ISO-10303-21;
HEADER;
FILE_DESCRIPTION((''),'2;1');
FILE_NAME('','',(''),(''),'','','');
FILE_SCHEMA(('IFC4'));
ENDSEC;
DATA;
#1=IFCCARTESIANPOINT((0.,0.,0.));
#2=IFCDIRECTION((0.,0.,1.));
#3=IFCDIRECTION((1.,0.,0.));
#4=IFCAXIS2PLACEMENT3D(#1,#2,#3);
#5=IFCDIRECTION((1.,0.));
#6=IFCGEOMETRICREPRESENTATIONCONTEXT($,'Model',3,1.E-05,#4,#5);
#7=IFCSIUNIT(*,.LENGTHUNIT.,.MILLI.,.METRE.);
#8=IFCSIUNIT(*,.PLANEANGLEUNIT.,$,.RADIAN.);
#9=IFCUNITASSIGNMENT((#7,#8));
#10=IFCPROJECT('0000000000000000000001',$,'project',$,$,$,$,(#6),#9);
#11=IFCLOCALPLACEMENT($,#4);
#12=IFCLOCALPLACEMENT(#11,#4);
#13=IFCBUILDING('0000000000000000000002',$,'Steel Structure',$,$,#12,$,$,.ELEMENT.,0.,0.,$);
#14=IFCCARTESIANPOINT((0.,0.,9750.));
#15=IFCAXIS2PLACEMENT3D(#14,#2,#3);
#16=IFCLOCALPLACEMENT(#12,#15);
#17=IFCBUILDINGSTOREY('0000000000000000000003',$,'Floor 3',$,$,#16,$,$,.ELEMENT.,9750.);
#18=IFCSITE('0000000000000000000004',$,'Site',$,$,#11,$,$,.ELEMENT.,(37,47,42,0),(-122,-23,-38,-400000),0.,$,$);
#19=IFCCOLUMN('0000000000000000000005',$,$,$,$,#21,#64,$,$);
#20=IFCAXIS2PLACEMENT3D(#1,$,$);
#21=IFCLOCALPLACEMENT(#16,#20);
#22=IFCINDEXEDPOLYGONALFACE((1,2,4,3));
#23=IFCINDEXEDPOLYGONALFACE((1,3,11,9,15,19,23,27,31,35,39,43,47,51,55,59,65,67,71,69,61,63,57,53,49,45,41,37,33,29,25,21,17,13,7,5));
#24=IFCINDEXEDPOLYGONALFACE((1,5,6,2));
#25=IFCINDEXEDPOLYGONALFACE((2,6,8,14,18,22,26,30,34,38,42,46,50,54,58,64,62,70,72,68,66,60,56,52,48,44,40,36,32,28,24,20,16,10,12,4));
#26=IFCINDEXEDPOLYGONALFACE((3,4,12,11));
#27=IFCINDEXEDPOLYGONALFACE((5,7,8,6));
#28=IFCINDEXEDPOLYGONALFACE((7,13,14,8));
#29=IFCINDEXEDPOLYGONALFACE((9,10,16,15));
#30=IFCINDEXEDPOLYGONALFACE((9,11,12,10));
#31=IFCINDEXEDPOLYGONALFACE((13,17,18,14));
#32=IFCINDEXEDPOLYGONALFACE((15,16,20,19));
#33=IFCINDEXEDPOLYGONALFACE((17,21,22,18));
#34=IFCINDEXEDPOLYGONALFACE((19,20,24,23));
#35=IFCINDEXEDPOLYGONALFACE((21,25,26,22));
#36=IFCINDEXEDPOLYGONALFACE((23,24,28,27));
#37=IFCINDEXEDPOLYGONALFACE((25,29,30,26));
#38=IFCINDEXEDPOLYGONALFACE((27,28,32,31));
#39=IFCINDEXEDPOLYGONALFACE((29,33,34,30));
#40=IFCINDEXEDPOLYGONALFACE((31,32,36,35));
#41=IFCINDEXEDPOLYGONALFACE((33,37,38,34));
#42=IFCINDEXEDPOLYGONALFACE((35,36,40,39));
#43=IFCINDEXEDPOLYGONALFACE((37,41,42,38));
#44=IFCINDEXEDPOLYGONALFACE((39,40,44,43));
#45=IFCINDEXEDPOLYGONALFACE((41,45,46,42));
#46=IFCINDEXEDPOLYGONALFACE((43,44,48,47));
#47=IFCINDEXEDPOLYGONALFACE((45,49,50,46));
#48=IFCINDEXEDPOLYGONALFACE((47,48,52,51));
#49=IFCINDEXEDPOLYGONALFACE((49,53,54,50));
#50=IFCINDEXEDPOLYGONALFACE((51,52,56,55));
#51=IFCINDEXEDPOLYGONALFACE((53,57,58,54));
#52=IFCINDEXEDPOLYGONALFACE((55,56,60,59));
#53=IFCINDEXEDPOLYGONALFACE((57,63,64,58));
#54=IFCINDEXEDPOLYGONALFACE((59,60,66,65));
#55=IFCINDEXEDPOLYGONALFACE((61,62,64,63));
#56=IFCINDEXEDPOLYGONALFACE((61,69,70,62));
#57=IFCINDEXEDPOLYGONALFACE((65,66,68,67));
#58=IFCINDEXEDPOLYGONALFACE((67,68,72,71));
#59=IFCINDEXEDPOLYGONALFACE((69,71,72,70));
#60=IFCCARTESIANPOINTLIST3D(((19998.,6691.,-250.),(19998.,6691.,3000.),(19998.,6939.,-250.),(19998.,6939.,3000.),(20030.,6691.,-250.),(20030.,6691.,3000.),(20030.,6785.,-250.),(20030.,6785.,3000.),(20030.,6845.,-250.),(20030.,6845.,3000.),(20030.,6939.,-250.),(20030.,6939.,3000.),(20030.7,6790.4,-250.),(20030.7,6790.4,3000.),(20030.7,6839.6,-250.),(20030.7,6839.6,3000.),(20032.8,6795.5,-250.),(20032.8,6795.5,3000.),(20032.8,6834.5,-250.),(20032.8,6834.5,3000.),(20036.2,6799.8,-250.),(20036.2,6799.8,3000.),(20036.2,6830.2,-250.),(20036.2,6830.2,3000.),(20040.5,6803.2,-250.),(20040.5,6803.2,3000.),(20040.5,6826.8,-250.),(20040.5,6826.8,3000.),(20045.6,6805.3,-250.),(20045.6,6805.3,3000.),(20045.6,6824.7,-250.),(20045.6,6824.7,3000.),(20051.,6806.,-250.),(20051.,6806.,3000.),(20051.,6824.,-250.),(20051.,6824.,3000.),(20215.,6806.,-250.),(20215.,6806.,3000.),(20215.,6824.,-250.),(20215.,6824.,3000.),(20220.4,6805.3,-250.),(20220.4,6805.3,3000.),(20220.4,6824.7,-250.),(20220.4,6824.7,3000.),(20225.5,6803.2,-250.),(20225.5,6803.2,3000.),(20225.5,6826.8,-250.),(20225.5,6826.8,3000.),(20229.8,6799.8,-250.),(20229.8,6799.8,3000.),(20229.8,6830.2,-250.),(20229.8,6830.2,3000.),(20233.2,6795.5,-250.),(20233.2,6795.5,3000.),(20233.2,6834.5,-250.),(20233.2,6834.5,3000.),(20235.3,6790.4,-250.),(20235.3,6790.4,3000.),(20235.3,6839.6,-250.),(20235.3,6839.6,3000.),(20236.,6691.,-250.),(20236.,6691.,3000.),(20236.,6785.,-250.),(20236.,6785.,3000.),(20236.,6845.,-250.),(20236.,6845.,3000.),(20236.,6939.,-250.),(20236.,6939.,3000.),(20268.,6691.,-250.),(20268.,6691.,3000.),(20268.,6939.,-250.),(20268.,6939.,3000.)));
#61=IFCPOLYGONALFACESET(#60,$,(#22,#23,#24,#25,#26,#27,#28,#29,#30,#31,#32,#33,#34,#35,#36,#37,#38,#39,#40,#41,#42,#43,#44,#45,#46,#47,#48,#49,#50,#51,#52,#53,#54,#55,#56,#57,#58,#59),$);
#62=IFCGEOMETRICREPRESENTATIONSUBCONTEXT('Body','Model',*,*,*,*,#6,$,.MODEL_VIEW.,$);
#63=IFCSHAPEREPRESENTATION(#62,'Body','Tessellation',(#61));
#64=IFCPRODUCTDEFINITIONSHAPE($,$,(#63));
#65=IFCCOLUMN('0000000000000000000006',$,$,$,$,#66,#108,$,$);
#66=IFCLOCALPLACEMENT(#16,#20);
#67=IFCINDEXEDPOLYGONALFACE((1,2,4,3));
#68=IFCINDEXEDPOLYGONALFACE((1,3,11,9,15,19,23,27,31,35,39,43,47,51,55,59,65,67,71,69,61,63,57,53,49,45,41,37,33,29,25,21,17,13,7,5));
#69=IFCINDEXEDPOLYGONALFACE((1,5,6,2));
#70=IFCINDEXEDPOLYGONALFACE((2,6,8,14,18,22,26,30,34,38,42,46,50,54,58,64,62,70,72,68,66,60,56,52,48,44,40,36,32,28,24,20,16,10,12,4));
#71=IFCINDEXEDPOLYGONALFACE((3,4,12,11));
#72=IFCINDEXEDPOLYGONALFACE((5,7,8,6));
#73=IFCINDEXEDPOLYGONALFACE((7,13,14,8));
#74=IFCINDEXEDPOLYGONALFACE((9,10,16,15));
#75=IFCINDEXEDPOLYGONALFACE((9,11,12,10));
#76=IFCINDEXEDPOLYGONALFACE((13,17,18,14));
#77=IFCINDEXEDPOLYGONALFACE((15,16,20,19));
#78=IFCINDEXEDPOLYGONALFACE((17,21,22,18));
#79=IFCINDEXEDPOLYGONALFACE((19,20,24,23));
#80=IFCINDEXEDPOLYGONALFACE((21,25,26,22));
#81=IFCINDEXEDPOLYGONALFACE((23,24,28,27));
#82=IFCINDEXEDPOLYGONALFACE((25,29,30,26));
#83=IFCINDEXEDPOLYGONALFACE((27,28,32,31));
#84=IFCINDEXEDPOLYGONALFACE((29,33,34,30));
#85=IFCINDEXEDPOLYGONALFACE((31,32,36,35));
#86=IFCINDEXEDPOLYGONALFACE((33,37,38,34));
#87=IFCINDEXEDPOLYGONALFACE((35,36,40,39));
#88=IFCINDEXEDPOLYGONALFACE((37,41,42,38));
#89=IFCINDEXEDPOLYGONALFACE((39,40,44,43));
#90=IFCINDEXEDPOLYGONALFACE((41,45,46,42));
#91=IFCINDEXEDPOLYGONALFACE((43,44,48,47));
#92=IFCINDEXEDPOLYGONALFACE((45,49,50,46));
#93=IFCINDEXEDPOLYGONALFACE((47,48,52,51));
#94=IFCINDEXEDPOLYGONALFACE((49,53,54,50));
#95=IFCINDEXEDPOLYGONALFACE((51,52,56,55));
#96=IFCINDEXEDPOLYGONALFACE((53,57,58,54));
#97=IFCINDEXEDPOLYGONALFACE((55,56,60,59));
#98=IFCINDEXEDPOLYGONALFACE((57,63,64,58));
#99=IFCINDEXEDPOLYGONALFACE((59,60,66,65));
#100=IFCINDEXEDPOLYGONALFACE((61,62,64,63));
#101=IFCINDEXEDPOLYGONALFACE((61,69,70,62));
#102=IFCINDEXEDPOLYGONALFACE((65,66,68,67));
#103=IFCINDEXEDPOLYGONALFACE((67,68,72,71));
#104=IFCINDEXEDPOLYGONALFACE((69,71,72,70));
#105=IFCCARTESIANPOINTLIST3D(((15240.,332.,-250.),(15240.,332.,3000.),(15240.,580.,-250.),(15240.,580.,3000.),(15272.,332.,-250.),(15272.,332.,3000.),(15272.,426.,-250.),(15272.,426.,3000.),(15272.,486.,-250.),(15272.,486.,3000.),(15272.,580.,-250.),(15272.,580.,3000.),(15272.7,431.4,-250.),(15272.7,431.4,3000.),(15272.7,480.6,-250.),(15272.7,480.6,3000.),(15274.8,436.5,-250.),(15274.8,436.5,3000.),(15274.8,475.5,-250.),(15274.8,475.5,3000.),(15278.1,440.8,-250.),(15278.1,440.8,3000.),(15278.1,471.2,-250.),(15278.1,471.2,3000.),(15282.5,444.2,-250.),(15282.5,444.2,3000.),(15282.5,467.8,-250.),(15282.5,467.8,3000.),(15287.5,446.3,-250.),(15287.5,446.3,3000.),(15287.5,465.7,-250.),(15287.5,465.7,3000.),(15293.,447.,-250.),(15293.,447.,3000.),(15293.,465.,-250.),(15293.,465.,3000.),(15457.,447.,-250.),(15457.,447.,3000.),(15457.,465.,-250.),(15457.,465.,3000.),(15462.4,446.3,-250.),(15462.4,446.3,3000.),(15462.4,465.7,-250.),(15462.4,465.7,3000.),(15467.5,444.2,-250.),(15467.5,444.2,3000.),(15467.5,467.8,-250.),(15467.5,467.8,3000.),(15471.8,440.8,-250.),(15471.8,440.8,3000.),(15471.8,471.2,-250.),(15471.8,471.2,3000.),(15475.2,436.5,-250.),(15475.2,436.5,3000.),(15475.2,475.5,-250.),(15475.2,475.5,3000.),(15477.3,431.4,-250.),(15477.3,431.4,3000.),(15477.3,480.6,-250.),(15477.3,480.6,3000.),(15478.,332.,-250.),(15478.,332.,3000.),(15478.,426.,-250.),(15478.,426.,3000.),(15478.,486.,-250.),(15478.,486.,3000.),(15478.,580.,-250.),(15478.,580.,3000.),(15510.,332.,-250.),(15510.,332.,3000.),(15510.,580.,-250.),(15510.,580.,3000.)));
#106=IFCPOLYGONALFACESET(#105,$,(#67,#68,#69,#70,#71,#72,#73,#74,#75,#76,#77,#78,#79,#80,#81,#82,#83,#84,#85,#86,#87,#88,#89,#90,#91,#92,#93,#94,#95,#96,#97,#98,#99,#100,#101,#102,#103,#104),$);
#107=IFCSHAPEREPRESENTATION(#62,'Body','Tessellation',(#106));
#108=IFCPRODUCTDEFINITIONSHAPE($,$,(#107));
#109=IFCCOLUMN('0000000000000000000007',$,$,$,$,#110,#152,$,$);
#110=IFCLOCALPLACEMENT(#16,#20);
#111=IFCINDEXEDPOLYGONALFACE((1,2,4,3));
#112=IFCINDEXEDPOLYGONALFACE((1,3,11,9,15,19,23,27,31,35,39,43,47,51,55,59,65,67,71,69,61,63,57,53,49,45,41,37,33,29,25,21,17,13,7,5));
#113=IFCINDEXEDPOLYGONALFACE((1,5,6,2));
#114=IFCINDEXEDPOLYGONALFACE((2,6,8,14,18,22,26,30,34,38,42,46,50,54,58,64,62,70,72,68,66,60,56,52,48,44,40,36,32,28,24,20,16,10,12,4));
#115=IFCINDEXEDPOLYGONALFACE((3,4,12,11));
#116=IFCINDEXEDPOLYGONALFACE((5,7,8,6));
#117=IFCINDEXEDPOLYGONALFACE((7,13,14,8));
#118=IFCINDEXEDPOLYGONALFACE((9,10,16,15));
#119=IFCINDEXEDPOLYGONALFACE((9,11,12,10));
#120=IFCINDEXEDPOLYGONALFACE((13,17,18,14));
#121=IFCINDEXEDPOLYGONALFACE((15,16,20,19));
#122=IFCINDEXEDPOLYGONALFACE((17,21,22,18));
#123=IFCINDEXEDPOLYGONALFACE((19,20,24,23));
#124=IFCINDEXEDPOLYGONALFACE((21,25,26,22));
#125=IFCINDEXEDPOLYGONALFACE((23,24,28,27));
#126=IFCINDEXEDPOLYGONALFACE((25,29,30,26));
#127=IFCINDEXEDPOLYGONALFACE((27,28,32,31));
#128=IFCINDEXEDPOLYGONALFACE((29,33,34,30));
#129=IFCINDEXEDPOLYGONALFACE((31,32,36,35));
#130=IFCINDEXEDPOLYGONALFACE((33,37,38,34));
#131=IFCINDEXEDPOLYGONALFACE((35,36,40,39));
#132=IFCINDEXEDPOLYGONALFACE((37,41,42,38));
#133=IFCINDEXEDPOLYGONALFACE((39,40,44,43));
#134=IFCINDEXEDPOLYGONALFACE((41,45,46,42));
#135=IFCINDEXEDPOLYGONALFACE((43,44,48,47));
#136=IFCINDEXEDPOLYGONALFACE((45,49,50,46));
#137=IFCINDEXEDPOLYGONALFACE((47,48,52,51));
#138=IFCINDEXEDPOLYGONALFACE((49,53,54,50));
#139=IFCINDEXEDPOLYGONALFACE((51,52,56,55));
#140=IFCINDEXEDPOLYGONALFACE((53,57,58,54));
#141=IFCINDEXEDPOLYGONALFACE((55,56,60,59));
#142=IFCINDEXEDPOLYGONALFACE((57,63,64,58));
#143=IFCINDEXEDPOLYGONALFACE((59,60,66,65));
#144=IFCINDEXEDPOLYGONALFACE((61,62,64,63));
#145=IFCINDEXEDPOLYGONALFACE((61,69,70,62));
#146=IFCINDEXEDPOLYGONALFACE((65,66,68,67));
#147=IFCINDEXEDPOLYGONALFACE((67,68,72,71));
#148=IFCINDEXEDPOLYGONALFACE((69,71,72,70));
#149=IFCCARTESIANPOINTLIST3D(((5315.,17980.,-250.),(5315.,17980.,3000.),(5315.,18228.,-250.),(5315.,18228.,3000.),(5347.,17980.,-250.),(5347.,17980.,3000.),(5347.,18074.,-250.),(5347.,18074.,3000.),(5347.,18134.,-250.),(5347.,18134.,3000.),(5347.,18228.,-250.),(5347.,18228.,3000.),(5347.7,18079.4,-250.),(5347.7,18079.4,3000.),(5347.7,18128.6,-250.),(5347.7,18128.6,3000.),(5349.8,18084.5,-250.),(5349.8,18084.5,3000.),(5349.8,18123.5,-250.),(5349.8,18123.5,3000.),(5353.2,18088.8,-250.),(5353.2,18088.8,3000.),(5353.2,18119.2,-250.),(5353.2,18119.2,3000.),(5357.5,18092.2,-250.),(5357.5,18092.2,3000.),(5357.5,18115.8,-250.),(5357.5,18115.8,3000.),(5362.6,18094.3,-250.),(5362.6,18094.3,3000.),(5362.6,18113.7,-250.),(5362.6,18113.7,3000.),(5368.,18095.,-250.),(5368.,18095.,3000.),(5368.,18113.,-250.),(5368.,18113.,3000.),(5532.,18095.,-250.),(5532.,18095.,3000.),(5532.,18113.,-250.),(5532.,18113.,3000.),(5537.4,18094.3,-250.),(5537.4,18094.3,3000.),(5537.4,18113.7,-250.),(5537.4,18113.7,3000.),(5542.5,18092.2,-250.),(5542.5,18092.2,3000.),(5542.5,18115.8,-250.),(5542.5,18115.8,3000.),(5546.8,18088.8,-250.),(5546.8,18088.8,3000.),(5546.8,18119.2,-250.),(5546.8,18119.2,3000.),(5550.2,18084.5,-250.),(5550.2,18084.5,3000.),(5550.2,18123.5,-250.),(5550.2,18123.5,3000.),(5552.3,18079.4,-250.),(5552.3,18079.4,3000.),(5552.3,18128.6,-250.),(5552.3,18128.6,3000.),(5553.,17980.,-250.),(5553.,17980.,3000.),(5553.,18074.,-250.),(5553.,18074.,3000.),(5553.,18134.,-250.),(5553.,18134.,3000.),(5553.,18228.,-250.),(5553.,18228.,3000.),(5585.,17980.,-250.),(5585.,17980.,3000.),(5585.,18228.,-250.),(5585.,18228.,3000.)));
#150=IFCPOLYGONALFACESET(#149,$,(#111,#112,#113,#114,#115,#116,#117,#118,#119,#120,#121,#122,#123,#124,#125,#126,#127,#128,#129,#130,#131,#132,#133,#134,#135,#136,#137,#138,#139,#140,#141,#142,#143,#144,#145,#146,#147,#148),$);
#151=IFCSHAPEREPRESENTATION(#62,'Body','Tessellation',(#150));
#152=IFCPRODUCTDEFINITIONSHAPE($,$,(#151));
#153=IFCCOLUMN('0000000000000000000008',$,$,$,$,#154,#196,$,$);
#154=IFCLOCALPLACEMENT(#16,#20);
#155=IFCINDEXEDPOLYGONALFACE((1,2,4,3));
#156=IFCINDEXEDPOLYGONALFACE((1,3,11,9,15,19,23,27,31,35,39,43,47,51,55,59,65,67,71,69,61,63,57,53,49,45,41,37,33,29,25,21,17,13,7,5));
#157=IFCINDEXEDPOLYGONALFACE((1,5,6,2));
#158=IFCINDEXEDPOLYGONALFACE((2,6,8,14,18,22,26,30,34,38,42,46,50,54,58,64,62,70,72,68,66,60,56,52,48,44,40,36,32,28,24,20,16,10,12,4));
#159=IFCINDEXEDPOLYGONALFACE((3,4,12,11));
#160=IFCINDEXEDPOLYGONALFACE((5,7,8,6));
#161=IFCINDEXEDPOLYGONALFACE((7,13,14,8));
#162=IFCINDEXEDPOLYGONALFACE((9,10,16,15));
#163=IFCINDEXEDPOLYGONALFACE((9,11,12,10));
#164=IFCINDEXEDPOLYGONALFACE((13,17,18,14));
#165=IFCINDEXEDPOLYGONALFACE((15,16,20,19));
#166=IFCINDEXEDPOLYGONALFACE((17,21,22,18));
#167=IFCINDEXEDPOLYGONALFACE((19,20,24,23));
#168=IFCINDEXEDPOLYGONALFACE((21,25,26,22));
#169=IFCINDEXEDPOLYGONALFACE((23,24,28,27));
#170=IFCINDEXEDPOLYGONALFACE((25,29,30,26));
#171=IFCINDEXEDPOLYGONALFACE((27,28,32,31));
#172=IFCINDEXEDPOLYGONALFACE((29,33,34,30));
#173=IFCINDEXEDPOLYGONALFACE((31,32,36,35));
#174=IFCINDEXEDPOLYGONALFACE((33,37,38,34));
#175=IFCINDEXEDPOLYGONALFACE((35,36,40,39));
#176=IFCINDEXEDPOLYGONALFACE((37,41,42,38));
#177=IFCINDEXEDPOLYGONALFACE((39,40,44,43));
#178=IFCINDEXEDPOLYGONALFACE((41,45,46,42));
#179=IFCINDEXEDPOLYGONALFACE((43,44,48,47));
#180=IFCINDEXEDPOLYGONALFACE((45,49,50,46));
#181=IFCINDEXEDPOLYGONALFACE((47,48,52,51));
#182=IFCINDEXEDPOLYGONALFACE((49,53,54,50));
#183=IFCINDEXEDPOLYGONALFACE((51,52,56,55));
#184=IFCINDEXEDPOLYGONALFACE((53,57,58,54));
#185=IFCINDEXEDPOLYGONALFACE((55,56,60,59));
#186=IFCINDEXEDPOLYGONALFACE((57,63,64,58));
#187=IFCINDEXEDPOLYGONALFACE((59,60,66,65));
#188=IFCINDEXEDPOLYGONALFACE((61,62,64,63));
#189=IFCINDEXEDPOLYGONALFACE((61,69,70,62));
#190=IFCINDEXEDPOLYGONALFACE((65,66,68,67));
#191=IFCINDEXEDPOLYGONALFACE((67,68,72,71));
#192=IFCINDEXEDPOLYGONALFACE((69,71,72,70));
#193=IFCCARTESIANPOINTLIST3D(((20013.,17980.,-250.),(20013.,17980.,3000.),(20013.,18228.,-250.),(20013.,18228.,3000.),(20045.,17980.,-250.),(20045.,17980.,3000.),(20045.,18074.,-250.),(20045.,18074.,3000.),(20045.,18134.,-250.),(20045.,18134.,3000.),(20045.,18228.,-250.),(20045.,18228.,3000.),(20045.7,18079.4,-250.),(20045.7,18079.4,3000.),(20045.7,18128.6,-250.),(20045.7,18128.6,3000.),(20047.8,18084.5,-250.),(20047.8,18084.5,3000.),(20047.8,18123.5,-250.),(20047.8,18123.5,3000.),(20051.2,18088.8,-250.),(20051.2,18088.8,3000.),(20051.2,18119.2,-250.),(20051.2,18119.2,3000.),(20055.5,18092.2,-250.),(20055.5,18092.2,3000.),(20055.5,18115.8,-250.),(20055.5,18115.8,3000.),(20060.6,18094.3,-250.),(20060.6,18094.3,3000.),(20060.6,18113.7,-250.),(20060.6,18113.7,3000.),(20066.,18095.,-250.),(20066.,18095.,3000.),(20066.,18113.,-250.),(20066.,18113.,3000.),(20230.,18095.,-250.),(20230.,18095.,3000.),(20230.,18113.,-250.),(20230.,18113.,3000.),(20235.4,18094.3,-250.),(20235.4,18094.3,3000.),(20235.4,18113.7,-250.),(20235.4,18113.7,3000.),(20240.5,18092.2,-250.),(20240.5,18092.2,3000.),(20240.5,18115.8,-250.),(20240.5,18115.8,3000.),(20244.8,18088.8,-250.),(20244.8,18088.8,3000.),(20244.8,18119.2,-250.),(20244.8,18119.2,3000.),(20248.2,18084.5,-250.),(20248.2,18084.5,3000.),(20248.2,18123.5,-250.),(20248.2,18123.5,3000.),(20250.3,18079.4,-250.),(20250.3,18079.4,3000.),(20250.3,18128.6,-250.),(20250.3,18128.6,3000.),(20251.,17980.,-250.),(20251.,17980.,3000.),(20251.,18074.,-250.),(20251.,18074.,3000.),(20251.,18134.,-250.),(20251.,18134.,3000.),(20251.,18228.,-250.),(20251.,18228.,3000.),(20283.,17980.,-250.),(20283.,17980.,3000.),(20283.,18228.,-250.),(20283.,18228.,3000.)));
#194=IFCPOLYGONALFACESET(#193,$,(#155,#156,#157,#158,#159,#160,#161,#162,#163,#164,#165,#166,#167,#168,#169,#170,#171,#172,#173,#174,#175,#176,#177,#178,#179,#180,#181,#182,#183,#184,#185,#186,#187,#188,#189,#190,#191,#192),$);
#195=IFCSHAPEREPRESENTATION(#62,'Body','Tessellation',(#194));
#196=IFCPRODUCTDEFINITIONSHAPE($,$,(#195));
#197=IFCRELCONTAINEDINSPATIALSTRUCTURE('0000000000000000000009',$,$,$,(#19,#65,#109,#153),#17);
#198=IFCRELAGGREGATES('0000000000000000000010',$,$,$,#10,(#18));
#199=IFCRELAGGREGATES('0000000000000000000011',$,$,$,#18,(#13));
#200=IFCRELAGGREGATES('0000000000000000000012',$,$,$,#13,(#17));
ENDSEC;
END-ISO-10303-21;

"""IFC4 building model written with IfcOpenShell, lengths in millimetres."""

from ifc_helpers import new_model, si_unit, direction, frame, origin_with_axes, origin_2d_with_axis, place, context, subcontext, project, spatial, i_section, extrude, element, save


model = new_model("IFC4")

# Units and contexts
model_context = context("Model", 3, precision=1e-05, world=origin_with_axes(), true_north=direction((1.0, 0.0)))
body_context = subcontext(model_context, "Body", "Model", "MODEL_VIEW")
ifc_project = project(units=[si_unit("LENGTHUNIT", "METRE", prefix="MILLI"), si_unit("PLANEANGLEUNIT", "RADIAN")], contexts=[model_context])

# Site, building, storey
site_placement = place(None, origin_with_axes())
site = spatial("IfcSite", under=ifc_project, at=site_placement, Name="Site", CompositionType="ELEMENT", RefLatitude=(37, 47, 42, 0), RefLongitude=(-122, -23, -38, -400000), RefElevation=0.0)
building_placement = place(site_placement, origin_with_axes())
building = spatial("IfcBuilding", under=site, at=building_placement, Name="Steel Structure", CompositionType="ELEMENT", ElevationOfRefHeight=0.0, ElevationOfTerrain=0.0)
storey_placement = place(building_placement, frame((0.0, 0.0, 9750.0), z_axis=(0.0, 0.0, 1.0), x_axis=(1.0, 0.0, 0.0)))
storey = spatial("IfcBuildingStorey", under=building, at=storey_placement, Name="Floor 3", CompositionType="ELEMENT", Elevation=9750.0)

# Columns
for number, where, z_axis, x_axis in (
    (1, (20133.0, 6815.0, -250.0), (0.0, 0.0, 1.0), (0.0, -1.0, 0.0)),
):
    element("IfcColumn", number, at=place(storey_placement, frame(where, z_axis=z_axis, x_axis=x_axis)), inside=storey, context=body_context, shape_type="SweptSolid", body=[
        extrude(i_section(OverallWidth=248.0, OverallDepth=270.0, WebThickness=18.0, FlangeThickness=32.0, FilletRadius=21.0, at=origin_2d_with_axis()), origin_with_axes(), (0.0, 0.0, 1.0), 3250.0),
    ])
column_1_placement = place(storey_placement, frame((15375.0, 456.0, -250.0), z_axis=(0.0, 0.0, 1.0), x_axis=(0.0, 1.0, 0.0)))
element("IfcColumn", 2, at=column_1_placement, inside=storey, context=body_context, shape_type="SweptSolid", body=[
    extrude(i_section(OverallWidth=248.0, OverallDepth=270.0, WebThickness=18.0, FlangeThickness=32.0, FilletRadius=21.0, at=origin_2d_with_axis()), origin_with_axes(), (0.0, 0.0, 1.0), 3250.0),
])
for number, where, z_axis, x_axis in (
    (3, (5450.0, 18104.0, -250.0), (0.0, 0.0, 1.0), (0.0, -1.0, 0.0)),
    (4, (20148.0, 18104.0, -250.0), (0.0, 0.0, 1.0), (0.0, -1.0, 0.0)),
):
    element("IfcColumn", number, at=place(storey_placement, frame(where, z_axis=z_axis, x_axis=x_axis)), inside=storey, context=body_context, shape_type="SweptSolid", body=[
        extrude(i_section(OverallWidth=248.0, OverallDepth=270.0, WebThickness=18.0, FlangeThickness=32.0, FilletRadius=21.0, at=origin_2d_with_axis()), origin_with_axes(), (0.0, 0.0, 1.0), 3250.0),
    ])

save(model, "model.ifc")
